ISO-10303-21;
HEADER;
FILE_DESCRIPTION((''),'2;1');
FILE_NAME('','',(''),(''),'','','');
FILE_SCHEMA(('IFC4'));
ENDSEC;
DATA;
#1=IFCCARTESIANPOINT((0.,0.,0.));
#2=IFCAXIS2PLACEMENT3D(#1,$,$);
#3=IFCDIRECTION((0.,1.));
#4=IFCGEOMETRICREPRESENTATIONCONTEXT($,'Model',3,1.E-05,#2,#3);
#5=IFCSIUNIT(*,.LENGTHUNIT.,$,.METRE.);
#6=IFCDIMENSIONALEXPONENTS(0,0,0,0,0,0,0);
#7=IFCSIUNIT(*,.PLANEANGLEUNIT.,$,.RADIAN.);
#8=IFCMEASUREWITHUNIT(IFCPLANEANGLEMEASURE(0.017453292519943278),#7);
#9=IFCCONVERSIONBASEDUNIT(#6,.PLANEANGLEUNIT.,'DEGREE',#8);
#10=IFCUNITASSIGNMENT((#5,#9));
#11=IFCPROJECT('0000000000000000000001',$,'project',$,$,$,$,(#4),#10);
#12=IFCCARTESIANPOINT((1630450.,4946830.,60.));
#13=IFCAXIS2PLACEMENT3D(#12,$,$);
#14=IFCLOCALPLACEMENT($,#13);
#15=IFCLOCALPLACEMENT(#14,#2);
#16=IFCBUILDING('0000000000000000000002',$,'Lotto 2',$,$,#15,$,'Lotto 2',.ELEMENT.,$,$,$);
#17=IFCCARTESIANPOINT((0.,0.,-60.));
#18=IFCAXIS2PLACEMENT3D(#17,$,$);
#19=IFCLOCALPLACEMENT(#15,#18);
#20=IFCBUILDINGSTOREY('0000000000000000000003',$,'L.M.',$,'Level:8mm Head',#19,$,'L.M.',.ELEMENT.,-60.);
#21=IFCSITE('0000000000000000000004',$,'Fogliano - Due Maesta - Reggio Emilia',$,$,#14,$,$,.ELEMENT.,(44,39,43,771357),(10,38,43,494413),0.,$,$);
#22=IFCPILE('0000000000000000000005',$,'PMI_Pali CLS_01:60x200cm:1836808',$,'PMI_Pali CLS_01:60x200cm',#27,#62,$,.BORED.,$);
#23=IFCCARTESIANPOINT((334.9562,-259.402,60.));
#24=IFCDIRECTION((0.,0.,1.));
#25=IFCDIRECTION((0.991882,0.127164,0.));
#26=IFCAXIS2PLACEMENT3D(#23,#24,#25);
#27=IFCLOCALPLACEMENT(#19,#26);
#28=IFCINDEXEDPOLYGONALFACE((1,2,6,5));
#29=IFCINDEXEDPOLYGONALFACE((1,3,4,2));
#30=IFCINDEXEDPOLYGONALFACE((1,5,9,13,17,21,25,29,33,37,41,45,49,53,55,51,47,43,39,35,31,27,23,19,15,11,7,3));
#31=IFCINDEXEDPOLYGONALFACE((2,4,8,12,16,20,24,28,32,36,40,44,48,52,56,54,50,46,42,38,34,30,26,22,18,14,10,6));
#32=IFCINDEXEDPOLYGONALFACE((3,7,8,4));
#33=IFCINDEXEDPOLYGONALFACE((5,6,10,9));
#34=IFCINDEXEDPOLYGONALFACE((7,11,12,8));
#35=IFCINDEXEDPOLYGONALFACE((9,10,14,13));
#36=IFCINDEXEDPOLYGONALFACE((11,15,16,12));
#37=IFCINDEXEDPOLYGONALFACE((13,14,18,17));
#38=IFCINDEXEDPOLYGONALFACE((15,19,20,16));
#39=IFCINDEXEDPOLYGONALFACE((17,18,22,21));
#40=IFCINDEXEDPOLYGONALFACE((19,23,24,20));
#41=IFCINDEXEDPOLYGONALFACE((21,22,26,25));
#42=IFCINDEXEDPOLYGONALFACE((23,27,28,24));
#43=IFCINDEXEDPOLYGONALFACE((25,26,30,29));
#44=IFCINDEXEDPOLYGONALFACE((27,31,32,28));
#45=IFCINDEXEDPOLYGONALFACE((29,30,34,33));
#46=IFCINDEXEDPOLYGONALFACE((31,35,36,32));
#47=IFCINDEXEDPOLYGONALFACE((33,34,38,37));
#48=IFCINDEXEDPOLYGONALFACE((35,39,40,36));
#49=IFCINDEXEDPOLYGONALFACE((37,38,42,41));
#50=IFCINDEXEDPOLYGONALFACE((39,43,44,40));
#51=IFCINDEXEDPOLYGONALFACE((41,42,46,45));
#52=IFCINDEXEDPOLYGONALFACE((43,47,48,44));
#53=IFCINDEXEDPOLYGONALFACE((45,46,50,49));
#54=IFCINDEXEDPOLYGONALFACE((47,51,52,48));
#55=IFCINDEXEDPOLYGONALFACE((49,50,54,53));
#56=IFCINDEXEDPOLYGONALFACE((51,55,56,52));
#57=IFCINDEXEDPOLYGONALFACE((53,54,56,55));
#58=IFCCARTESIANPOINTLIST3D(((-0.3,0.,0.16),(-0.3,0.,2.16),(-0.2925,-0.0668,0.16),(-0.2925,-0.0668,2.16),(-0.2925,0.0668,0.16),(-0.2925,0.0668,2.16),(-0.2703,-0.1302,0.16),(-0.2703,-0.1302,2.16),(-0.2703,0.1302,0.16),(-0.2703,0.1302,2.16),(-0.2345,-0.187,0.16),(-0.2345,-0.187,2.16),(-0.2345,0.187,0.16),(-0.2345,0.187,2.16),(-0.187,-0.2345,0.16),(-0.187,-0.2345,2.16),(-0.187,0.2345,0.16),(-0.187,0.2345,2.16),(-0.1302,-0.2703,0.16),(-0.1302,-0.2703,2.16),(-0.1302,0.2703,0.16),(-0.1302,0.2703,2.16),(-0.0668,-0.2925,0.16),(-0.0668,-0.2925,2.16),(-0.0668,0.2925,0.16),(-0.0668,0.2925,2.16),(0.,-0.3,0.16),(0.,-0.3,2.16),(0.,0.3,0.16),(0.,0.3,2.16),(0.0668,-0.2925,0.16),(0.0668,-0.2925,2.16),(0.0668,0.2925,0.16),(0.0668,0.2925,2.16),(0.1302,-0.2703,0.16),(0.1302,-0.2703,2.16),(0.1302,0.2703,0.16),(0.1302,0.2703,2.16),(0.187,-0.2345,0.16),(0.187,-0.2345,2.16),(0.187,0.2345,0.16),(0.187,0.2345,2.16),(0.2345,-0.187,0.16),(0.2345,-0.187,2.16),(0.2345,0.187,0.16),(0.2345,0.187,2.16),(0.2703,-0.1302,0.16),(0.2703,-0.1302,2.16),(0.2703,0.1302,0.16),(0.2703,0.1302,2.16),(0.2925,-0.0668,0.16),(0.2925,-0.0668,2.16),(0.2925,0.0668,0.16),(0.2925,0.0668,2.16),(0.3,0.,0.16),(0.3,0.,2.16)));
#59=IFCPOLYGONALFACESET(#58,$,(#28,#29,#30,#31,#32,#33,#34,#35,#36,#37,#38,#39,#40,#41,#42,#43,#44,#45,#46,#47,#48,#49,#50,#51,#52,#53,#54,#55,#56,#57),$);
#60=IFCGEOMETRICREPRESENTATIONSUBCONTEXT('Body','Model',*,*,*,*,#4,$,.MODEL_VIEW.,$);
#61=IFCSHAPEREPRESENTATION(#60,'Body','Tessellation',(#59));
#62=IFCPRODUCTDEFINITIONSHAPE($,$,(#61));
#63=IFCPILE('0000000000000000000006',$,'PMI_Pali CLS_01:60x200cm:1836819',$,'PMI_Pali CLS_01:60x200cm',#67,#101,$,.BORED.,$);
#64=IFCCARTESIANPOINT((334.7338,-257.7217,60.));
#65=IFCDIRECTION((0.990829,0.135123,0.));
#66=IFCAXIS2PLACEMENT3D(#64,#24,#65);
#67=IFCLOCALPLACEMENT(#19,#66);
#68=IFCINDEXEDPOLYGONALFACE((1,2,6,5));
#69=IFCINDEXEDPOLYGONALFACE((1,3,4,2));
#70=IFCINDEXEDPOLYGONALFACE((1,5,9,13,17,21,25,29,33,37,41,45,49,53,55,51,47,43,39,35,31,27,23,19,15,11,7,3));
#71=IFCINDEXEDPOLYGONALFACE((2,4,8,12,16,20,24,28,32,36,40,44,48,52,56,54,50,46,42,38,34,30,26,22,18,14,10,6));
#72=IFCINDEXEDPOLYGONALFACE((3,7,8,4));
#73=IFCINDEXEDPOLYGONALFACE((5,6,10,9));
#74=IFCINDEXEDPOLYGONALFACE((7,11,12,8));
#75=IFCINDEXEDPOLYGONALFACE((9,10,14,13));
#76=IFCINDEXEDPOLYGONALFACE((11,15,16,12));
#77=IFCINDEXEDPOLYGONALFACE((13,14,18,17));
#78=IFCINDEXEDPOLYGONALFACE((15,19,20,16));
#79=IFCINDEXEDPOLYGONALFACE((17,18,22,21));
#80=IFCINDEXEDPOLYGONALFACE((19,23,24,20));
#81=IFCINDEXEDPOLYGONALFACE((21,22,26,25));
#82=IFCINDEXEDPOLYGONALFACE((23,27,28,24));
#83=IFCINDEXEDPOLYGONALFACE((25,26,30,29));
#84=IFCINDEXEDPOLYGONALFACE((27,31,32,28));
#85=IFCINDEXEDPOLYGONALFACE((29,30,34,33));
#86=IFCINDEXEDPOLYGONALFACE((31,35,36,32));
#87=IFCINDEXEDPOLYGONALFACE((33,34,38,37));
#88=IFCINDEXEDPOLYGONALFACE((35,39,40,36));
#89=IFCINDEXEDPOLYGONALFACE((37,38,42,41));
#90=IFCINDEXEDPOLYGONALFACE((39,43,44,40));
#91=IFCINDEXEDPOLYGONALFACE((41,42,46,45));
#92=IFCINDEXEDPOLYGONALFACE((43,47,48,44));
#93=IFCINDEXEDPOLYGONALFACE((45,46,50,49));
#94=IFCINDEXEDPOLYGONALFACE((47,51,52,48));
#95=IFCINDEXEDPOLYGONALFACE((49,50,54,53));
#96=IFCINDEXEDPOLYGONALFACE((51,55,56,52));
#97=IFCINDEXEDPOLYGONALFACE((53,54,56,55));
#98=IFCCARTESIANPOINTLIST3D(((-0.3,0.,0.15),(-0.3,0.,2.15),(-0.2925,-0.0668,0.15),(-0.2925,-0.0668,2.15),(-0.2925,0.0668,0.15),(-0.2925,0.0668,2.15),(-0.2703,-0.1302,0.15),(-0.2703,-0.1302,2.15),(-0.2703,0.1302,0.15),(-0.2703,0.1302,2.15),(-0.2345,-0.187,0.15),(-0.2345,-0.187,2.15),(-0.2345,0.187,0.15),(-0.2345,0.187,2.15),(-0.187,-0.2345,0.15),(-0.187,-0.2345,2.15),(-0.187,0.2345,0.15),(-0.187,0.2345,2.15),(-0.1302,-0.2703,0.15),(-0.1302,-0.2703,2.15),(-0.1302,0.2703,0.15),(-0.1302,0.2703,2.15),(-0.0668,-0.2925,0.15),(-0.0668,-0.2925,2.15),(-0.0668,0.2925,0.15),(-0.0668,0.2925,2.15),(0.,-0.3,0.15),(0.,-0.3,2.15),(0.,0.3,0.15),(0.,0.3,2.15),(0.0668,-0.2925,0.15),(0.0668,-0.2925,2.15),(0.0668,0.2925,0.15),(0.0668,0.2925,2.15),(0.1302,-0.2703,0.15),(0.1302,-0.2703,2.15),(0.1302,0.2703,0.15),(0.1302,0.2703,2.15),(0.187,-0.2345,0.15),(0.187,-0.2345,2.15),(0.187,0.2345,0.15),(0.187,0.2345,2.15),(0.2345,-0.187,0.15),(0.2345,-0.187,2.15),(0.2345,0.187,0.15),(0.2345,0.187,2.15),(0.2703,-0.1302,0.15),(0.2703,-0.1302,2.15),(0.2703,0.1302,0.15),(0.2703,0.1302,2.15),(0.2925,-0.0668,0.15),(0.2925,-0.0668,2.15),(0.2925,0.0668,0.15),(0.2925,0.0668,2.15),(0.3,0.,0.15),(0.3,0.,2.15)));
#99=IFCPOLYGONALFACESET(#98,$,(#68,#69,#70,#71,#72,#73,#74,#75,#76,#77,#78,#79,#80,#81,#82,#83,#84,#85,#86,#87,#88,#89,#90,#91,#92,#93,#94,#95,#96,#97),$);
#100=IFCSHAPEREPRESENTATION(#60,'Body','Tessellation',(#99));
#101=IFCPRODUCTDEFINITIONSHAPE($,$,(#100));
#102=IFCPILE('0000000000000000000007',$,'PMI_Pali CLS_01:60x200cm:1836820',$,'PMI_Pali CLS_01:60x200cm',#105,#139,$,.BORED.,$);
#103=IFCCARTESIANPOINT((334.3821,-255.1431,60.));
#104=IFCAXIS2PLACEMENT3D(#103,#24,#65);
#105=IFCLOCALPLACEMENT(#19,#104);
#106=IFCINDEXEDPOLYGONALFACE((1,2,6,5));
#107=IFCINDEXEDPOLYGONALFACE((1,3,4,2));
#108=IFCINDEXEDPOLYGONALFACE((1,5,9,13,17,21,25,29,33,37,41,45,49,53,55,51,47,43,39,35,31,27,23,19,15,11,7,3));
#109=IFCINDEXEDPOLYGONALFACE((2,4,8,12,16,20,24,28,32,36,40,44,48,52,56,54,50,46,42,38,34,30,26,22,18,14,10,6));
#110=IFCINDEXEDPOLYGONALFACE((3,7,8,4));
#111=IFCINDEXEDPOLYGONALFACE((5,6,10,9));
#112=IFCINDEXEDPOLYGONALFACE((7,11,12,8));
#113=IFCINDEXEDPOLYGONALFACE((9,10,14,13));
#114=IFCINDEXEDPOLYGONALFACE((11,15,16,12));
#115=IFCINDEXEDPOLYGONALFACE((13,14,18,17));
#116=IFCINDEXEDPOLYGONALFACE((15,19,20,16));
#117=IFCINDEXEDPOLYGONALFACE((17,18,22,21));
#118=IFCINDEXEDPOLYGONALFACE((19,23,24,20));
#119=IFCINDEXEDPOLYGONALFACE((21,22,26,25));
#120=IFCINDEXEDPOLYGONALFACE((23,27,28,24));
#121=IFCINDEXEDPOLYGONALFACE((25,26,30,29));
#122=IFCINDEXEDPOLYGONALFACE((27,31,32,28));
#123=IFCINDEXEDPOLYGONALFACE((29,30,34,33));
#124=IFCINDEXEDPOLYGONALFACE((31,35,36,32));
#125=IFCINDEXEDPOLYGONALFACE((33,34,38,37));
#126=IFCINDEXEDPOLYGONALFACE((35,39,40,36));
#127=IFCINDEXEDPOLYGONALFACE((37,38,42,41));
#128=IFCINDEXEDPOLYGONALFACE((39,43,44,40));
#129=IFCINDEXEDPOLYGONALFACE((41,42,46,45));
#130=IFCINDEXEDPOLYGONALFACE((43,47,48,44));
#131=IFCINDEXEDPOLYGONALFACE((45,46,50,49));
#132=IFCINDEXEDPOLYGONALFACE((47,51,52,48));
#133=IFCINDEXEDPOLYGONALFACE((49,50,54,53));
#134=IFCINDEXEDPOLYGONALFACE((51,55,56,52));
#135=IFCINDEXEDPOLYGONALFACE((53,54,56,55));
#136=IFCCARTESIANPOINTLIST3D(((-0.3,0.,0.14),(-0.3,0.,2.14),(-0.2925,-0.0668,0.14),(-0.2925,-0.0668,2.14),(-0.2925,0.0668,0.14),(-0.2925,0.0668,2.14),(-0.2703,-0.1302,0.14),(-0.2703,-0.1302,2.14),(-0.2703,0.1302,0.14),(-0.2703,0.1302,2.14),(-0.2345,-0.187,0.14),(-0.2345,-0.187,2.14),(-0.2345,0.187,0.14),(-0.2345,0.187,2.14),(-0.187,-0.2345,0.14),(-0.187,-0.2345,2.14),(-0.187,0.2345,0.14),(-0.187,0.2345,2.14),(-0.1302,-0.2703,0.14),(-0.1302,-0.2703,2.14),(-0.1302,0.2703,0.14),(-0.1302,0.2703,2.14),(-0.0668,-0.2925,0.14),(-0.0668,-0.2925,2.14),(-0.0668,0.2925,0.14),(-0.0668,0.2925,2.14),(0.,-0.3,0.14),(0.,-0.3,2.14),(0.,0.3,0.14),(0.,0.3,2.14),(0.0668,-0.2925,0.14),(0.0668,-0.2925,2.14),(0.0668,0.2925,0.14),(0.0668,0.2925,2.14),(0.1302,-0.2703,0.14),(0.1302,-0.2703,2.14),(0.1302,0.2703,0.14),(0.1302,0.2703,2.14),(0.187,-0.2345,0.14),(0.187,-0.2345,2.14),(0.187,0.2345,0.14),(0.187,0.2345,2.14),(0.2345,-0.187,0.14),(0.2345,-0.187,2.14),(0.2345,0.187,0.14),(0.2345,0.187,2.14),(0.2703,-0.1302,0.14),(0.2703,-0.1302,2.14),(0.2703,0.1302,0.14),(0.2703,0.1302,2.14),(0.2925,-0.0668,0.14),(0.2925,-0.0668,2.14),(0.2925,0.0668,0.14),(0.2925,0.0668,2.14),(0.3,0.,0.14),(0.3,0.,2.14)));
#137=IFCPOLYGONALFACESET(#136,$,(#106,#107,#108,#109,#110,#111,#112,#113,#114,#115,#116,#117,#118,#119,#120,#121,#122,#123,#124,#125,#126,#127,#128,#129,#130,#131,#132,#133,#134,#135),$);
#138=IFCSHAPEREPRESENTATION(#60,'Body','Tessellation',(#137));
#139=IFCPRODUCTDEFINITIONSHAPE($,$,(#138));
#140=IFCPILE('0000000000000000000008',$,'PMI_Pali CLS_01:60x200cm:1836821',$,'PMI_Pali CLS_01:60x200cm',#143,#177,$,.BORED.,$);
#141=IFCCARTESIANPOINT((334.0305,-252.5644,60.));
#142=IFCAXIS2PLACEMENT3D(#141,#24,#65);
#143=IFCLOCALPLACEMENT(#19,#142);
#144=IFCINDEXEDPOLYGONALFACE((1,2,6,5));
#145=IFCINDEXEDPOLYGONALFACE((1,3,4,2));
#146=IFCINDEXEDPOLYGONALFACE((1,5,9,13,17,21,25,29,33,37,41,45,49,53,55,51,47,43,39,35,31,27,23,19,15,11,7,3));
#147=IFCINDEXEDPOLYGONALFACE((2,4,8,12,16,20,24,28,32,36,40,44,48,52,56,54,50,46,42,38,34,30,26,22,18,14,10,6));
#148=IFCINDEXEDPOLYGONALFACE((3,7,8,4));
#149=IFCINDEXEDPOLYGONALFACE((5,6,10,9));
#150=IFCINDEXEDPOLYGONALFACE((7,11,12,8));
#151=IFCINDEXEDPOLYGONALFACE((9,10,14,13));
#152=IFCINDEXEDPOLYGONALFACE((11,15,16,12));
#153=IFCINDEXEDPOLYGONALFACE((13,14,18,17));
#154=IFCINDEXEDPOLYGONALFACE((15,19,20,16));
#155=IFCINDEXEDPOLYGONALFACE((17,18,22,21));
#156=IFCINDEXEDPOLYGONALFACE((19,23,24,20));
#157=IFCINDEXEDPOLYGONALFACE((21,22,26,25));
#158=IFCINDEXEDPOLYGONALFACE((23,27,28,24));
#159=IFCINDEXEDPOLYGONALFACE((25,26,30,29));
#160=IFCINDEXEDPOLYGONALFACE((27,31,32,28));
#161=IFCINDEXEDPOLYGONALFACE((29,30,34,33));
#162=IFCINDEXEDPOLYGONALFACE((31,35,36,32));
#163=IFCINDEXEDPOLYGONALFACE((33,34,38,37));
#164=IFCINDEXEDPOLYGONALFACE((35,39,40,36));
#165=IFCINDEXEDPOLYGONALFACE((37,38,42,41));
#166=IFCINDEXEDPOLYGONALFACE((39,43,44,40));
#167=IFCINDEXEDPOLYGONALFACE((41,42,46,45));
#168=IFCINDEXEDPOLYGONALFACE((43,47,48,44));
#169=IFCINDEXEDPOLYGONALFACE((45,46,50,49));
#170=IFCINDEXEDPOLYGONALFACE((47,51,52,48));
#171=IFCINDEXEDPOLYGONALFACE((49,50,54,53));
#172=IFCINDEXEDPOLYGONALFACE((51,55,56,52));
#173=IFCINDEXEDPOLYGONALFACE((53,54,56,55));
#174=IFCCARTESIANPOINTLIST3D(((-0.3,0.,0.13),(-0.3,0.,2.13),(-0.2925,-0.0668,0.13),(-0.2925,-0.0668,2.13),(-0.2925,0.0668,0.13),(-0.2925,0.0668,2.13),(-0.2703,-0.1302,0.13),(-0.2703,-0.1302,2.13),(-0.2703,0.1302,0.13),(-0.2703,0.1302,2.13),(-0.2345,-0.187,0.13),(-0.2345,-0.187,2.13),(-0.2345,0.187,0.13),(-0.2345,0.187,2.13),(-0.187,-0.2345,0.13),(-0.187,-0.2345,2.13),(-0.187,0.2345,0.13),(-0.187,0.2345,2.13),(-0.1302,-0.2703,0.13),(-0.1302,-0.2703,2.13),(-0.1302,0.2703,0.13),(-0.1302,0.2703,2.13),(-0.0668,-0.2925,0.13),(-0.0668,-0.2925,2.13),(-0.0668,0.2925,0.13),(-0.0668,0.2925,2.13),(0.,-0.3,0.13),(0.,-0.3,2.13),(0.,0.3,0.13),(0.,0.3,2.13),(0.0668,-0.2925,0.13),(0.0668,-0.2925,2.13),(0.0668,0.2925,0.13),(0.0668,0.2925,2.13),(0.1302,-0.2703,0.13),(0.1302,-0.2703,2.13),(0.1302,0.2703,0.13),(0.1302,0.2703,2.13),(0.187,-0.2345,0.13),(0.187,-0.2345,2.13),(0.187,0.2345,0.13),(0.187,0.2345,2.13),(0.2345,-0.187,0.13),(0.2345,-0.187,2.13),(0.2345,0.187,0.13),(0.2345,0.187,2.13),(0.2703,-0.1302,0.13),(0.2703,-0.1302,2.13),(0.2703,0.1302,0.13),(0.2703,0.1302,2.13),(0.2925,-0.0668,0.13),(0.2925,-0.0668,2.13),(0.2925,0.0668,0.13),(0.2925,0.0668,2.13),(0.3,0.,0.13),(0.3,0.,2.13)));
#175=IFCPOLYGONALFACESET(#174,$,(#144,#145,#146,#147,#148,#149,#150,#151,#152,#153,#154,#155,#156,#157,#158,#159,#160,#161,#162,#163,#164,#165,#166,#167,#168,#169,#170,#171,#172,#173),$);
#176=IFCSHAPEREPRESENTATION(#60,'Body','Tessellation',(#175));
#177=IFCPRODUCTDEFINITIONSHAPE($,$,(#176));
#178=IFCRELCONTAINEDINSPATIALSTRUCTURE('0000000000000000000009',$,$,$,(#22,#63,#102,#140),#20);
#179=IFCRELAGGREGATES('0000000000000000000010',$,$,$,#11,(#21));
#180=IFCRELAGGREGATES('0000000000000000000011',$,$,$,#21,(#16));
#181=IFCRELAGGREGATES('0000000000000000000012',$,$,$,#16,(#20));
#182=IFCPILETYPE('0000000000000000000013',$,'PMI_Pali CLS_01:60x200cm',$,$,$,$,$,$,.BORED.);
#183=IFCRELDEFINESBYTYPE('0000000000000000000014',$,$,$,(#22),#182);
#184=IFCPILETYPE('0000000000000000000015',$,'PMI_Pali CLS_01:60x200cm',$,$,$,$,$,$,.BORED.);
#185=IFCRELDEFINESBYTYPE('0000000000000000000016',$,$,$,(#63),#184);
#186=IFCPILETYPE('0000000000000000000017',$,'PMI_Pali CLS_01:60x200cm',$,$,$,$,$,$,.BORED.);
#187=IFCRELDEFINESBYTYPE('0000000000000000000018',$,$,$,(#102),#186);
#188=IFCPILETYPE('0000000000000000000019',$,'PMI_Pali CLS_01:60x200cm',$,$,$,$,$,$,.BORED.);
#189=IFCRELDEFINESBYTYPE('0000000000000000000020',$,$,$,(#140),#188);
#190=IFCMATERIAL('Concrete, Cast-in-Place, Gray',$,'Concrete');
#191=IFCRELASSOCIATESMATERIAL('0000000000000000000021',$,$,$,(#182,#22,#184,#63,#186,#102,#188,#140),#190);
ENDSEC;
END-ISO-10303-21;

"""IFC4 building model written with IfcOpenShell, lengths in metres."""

from ifc_helpers import new_model, entity, si_unit, converted_unit, direction, frame, origin, place, context, subcontext, project, spatial, arc, indexed_curve, outline, extrude, source, transform, mapped, material, type_object, type_shapes, element, save


model = new_model("IFC4")

# Units and contexts
model_context = context("Model", 3, precision=1e-05, world=origin(), true_north=direction((0.0, 1.0)))
body_context = subcontext(model_context, "Body", "Model", "MODEL_VIEW")
ifc_project = project(units=[si_unit("LENGTHUNIT", "METRE"), converted_unit("PLANEANGLEUNIT", "DEGREE", entity("IfcPlaneAngleMeasure", 0.017453292519943278), si_unit("PLANEANGLEUNIT", "RADIAN"), dimensions=[0, 0, 0, 0, 0, 0, 0])], contexts=[model_context])

# Site, building, storey
site_placement = place(None, frame((1630450.0, 4946830.0, 60.0)))
site = spatial("IfcSite", under=ifc_project, at=site_placement, Name="Fogliano - Due Maesta - Reggio Emilia", CompositionType="ELEMENT", RefLatitude=(44, 39, 43, 771357), RefLongitude=(10, 38, 43, 494413), RefElevation=0.0)
building_placement = place(site_placement, origin())
building = spatial("IfcBuilding", under=site, at=building_placement, Name="Lotto 2", LongName="Lotto 2", CompositionType="ELEMENT")
storey_placement = place(building_placement, frame((0.0, 0.0, -60.0)))
storey = spatial("IfcBuildingStorey", under=building, at=storey_placement, Name="L.M.", ObjectType="Level:8mm Head", LongName="L.M.", CompositionType="ELEMENT", Elevation=-60.0)

# Piles
ifc_material_1 = material(Name="Concrete, Cast-in-Place, Gray", Category="Concrete")
pile_type_1 = type_object("IfcPileType", Name="PMI_Pali CLS_01:60x200cm", PredefinedType="BORED", material=ifc_material_1)
shared_shape_1 = source(origin(), body_context, "Body", "SweptSolid", [
    extrude(outline(indexed_curve([(-0.3, 0.0), (0.0, -0.3), (0.3, 0.0), (0.0, 0.3)], segments=[arc(1, 2, 3), arc(3, 4, 1)], self_intersect=False)), frame((0.0, 0.0, 0.16)), (0.0, 0.0, 1.0), 2.0),
])
type_shapes(pile_type_1, [shared_shape_1])
pile_1_placement = place(storey_placement, frame((334.9562, -259.402, 60.0), z_axis=(0.0, 0.0, 1.0), x_axis=(0.991882, 0.127164, 0.0)))
element("IfcPile", 1, at=pile_1_placement, inside=storey, type_object=pile_type_1, material=ifc_material_1, Name="PMI_Pali CLS_01:60x200cm:1836808", ObjectType="PMI_Pali CLS_01:60x200cm", PredefinedType="BORED", context=body_context, shape_type="MappedRepresentation", body=[
    mapped(shared_shape_1, transform((0.0, 0.0, 0.0), scale=1.0)),
])
pile_type_2 = type_object("IfcPileType", Name="PMI_Pali CLS_01:60x200cm", PredefinedType="BORED", material=ifc_material_1)
shared_shape_2 = source(origin(), body_context, "Body", "SweptSolid", [
    extrude(outline(indexed_curve([(-0.3, 0.0), (0.0, -0.3), (0.3, 0.0), (0.0, 0.3)], segments=[arc(1, 2, 3), arc(3, 4, 1)], self_intersect=False)), frame((0.0, 0.0, 0.15)), (0.0, 0.0, 1.0), 2.0),
])
type_shapes(pile_type_2, [shared_shape_2])
pile_2_placement = place(storey_placement, frame((334.7338, -257.7217, 60.0), z_axis=(0.0, 0.0, 1.0), x_axis=(0.990829, 0.135123, 0.0)))
element("IfcPile", 2, at=pile_2_placement, inside=storey, type_object=pile_type_2, material=ifc_material_1, Name="PMI_Pali CLS_01:60x200cm:1836819", ObjectType="PMI_Pali CLS_01:60x200cm", PredefinedType="BORED", context=body_context, shape_type="MappedRepresentation", body=[
    mapped(shared_shape_2, transform((0.0, 0.0, 0.0), scale=1.0)),
])
pile_type_3 = type_object("IfcPileType", Name="PMI_Pali CLS_01:60x200cm", PredefinedType="BORED", material=ifc_material_1)
shared_shape_3 = source(origin(), body_context, "Body", "SweptSolid", [
    extrude(outline(indexed_curve([(-0.3, 0.0), (0.0, -0.3), (0.3, 0.0), (0.0, 0.3)], segments=[arc(1, 2, 3), arc(3, 4, 1)], self_intersect=False)), frame((0.0, 0.0, 0.14)), (0.0, 0.0, 1.0), 2.0),
])
type_shapes(pile_type_3, [shared_shape_3])
pile_3_placement = place(storey_placement, frame((334.3821, -255.1431, 60.0), z_axis=(0.0, 0.0, 1.0), x_axis=(0.990829, 0.135123, 0.0)))
element("IfcPile", 3, at=pile_3_placement, inside=storey, type_object=pile_type_3, material=ifc_material_1, Name="PMI_Pali CLS_01:60x200cm:1836820", ObjectType="PMI_Pali CLS_01:60x200cm", PredefinedType="BORED", context=body_context, shape_type="MappedRepresentation", body=[
    mapped(shared_shape_3, transform((0.0, 0.0, 0.0), scale=1.0)),
])
pile_type_4 = type_object("IfcPileType", Name="PMI_Pali CLS_01:60x200cm", PredefinedType="BORED", material=ifc_material_1)
shared_shape_4 = source(origin(), body_context, "Body", "SweptSolid", [
    extrude(outline(indexed_curve([(-0.3, 0.0), (0.0, -0.3), (0.3, 0.0), (0.0, 0.3)], segments=[arc(1, 2, 3), arc(3, 4, 1)], self_intersect=False)), frame((0.0, 0.0, 0.13)), (0.0, 0.0, 1.0), 2.0),
])
type_shapes(pile_type_4, [shared_shape_4])
pile_4_placement = place(storey_placement, frame((334.0305, -252.5644, 60.0), z_axis=(0.0, 0.0, 1.0), x_axis=(0.990829, 0.135123, 0.0)))
element("IfcPile", 4, at=pile_4_placement, inside=storey, type_object=pile_type_4, material=ifc_material_1, Name="PMI_Pali CLS_01:60x200cm:1836821", ObjectType="PMI_Pali CLS_01:60x200cm", PredefinedType="BORED", context=body_context, shape_type="MappedRepresentation", body=[
    mapped(shared_shape_4, transform((0.0, 0.0, 0.0), scale=1.0)),
])

save(model, "model.ifc")
